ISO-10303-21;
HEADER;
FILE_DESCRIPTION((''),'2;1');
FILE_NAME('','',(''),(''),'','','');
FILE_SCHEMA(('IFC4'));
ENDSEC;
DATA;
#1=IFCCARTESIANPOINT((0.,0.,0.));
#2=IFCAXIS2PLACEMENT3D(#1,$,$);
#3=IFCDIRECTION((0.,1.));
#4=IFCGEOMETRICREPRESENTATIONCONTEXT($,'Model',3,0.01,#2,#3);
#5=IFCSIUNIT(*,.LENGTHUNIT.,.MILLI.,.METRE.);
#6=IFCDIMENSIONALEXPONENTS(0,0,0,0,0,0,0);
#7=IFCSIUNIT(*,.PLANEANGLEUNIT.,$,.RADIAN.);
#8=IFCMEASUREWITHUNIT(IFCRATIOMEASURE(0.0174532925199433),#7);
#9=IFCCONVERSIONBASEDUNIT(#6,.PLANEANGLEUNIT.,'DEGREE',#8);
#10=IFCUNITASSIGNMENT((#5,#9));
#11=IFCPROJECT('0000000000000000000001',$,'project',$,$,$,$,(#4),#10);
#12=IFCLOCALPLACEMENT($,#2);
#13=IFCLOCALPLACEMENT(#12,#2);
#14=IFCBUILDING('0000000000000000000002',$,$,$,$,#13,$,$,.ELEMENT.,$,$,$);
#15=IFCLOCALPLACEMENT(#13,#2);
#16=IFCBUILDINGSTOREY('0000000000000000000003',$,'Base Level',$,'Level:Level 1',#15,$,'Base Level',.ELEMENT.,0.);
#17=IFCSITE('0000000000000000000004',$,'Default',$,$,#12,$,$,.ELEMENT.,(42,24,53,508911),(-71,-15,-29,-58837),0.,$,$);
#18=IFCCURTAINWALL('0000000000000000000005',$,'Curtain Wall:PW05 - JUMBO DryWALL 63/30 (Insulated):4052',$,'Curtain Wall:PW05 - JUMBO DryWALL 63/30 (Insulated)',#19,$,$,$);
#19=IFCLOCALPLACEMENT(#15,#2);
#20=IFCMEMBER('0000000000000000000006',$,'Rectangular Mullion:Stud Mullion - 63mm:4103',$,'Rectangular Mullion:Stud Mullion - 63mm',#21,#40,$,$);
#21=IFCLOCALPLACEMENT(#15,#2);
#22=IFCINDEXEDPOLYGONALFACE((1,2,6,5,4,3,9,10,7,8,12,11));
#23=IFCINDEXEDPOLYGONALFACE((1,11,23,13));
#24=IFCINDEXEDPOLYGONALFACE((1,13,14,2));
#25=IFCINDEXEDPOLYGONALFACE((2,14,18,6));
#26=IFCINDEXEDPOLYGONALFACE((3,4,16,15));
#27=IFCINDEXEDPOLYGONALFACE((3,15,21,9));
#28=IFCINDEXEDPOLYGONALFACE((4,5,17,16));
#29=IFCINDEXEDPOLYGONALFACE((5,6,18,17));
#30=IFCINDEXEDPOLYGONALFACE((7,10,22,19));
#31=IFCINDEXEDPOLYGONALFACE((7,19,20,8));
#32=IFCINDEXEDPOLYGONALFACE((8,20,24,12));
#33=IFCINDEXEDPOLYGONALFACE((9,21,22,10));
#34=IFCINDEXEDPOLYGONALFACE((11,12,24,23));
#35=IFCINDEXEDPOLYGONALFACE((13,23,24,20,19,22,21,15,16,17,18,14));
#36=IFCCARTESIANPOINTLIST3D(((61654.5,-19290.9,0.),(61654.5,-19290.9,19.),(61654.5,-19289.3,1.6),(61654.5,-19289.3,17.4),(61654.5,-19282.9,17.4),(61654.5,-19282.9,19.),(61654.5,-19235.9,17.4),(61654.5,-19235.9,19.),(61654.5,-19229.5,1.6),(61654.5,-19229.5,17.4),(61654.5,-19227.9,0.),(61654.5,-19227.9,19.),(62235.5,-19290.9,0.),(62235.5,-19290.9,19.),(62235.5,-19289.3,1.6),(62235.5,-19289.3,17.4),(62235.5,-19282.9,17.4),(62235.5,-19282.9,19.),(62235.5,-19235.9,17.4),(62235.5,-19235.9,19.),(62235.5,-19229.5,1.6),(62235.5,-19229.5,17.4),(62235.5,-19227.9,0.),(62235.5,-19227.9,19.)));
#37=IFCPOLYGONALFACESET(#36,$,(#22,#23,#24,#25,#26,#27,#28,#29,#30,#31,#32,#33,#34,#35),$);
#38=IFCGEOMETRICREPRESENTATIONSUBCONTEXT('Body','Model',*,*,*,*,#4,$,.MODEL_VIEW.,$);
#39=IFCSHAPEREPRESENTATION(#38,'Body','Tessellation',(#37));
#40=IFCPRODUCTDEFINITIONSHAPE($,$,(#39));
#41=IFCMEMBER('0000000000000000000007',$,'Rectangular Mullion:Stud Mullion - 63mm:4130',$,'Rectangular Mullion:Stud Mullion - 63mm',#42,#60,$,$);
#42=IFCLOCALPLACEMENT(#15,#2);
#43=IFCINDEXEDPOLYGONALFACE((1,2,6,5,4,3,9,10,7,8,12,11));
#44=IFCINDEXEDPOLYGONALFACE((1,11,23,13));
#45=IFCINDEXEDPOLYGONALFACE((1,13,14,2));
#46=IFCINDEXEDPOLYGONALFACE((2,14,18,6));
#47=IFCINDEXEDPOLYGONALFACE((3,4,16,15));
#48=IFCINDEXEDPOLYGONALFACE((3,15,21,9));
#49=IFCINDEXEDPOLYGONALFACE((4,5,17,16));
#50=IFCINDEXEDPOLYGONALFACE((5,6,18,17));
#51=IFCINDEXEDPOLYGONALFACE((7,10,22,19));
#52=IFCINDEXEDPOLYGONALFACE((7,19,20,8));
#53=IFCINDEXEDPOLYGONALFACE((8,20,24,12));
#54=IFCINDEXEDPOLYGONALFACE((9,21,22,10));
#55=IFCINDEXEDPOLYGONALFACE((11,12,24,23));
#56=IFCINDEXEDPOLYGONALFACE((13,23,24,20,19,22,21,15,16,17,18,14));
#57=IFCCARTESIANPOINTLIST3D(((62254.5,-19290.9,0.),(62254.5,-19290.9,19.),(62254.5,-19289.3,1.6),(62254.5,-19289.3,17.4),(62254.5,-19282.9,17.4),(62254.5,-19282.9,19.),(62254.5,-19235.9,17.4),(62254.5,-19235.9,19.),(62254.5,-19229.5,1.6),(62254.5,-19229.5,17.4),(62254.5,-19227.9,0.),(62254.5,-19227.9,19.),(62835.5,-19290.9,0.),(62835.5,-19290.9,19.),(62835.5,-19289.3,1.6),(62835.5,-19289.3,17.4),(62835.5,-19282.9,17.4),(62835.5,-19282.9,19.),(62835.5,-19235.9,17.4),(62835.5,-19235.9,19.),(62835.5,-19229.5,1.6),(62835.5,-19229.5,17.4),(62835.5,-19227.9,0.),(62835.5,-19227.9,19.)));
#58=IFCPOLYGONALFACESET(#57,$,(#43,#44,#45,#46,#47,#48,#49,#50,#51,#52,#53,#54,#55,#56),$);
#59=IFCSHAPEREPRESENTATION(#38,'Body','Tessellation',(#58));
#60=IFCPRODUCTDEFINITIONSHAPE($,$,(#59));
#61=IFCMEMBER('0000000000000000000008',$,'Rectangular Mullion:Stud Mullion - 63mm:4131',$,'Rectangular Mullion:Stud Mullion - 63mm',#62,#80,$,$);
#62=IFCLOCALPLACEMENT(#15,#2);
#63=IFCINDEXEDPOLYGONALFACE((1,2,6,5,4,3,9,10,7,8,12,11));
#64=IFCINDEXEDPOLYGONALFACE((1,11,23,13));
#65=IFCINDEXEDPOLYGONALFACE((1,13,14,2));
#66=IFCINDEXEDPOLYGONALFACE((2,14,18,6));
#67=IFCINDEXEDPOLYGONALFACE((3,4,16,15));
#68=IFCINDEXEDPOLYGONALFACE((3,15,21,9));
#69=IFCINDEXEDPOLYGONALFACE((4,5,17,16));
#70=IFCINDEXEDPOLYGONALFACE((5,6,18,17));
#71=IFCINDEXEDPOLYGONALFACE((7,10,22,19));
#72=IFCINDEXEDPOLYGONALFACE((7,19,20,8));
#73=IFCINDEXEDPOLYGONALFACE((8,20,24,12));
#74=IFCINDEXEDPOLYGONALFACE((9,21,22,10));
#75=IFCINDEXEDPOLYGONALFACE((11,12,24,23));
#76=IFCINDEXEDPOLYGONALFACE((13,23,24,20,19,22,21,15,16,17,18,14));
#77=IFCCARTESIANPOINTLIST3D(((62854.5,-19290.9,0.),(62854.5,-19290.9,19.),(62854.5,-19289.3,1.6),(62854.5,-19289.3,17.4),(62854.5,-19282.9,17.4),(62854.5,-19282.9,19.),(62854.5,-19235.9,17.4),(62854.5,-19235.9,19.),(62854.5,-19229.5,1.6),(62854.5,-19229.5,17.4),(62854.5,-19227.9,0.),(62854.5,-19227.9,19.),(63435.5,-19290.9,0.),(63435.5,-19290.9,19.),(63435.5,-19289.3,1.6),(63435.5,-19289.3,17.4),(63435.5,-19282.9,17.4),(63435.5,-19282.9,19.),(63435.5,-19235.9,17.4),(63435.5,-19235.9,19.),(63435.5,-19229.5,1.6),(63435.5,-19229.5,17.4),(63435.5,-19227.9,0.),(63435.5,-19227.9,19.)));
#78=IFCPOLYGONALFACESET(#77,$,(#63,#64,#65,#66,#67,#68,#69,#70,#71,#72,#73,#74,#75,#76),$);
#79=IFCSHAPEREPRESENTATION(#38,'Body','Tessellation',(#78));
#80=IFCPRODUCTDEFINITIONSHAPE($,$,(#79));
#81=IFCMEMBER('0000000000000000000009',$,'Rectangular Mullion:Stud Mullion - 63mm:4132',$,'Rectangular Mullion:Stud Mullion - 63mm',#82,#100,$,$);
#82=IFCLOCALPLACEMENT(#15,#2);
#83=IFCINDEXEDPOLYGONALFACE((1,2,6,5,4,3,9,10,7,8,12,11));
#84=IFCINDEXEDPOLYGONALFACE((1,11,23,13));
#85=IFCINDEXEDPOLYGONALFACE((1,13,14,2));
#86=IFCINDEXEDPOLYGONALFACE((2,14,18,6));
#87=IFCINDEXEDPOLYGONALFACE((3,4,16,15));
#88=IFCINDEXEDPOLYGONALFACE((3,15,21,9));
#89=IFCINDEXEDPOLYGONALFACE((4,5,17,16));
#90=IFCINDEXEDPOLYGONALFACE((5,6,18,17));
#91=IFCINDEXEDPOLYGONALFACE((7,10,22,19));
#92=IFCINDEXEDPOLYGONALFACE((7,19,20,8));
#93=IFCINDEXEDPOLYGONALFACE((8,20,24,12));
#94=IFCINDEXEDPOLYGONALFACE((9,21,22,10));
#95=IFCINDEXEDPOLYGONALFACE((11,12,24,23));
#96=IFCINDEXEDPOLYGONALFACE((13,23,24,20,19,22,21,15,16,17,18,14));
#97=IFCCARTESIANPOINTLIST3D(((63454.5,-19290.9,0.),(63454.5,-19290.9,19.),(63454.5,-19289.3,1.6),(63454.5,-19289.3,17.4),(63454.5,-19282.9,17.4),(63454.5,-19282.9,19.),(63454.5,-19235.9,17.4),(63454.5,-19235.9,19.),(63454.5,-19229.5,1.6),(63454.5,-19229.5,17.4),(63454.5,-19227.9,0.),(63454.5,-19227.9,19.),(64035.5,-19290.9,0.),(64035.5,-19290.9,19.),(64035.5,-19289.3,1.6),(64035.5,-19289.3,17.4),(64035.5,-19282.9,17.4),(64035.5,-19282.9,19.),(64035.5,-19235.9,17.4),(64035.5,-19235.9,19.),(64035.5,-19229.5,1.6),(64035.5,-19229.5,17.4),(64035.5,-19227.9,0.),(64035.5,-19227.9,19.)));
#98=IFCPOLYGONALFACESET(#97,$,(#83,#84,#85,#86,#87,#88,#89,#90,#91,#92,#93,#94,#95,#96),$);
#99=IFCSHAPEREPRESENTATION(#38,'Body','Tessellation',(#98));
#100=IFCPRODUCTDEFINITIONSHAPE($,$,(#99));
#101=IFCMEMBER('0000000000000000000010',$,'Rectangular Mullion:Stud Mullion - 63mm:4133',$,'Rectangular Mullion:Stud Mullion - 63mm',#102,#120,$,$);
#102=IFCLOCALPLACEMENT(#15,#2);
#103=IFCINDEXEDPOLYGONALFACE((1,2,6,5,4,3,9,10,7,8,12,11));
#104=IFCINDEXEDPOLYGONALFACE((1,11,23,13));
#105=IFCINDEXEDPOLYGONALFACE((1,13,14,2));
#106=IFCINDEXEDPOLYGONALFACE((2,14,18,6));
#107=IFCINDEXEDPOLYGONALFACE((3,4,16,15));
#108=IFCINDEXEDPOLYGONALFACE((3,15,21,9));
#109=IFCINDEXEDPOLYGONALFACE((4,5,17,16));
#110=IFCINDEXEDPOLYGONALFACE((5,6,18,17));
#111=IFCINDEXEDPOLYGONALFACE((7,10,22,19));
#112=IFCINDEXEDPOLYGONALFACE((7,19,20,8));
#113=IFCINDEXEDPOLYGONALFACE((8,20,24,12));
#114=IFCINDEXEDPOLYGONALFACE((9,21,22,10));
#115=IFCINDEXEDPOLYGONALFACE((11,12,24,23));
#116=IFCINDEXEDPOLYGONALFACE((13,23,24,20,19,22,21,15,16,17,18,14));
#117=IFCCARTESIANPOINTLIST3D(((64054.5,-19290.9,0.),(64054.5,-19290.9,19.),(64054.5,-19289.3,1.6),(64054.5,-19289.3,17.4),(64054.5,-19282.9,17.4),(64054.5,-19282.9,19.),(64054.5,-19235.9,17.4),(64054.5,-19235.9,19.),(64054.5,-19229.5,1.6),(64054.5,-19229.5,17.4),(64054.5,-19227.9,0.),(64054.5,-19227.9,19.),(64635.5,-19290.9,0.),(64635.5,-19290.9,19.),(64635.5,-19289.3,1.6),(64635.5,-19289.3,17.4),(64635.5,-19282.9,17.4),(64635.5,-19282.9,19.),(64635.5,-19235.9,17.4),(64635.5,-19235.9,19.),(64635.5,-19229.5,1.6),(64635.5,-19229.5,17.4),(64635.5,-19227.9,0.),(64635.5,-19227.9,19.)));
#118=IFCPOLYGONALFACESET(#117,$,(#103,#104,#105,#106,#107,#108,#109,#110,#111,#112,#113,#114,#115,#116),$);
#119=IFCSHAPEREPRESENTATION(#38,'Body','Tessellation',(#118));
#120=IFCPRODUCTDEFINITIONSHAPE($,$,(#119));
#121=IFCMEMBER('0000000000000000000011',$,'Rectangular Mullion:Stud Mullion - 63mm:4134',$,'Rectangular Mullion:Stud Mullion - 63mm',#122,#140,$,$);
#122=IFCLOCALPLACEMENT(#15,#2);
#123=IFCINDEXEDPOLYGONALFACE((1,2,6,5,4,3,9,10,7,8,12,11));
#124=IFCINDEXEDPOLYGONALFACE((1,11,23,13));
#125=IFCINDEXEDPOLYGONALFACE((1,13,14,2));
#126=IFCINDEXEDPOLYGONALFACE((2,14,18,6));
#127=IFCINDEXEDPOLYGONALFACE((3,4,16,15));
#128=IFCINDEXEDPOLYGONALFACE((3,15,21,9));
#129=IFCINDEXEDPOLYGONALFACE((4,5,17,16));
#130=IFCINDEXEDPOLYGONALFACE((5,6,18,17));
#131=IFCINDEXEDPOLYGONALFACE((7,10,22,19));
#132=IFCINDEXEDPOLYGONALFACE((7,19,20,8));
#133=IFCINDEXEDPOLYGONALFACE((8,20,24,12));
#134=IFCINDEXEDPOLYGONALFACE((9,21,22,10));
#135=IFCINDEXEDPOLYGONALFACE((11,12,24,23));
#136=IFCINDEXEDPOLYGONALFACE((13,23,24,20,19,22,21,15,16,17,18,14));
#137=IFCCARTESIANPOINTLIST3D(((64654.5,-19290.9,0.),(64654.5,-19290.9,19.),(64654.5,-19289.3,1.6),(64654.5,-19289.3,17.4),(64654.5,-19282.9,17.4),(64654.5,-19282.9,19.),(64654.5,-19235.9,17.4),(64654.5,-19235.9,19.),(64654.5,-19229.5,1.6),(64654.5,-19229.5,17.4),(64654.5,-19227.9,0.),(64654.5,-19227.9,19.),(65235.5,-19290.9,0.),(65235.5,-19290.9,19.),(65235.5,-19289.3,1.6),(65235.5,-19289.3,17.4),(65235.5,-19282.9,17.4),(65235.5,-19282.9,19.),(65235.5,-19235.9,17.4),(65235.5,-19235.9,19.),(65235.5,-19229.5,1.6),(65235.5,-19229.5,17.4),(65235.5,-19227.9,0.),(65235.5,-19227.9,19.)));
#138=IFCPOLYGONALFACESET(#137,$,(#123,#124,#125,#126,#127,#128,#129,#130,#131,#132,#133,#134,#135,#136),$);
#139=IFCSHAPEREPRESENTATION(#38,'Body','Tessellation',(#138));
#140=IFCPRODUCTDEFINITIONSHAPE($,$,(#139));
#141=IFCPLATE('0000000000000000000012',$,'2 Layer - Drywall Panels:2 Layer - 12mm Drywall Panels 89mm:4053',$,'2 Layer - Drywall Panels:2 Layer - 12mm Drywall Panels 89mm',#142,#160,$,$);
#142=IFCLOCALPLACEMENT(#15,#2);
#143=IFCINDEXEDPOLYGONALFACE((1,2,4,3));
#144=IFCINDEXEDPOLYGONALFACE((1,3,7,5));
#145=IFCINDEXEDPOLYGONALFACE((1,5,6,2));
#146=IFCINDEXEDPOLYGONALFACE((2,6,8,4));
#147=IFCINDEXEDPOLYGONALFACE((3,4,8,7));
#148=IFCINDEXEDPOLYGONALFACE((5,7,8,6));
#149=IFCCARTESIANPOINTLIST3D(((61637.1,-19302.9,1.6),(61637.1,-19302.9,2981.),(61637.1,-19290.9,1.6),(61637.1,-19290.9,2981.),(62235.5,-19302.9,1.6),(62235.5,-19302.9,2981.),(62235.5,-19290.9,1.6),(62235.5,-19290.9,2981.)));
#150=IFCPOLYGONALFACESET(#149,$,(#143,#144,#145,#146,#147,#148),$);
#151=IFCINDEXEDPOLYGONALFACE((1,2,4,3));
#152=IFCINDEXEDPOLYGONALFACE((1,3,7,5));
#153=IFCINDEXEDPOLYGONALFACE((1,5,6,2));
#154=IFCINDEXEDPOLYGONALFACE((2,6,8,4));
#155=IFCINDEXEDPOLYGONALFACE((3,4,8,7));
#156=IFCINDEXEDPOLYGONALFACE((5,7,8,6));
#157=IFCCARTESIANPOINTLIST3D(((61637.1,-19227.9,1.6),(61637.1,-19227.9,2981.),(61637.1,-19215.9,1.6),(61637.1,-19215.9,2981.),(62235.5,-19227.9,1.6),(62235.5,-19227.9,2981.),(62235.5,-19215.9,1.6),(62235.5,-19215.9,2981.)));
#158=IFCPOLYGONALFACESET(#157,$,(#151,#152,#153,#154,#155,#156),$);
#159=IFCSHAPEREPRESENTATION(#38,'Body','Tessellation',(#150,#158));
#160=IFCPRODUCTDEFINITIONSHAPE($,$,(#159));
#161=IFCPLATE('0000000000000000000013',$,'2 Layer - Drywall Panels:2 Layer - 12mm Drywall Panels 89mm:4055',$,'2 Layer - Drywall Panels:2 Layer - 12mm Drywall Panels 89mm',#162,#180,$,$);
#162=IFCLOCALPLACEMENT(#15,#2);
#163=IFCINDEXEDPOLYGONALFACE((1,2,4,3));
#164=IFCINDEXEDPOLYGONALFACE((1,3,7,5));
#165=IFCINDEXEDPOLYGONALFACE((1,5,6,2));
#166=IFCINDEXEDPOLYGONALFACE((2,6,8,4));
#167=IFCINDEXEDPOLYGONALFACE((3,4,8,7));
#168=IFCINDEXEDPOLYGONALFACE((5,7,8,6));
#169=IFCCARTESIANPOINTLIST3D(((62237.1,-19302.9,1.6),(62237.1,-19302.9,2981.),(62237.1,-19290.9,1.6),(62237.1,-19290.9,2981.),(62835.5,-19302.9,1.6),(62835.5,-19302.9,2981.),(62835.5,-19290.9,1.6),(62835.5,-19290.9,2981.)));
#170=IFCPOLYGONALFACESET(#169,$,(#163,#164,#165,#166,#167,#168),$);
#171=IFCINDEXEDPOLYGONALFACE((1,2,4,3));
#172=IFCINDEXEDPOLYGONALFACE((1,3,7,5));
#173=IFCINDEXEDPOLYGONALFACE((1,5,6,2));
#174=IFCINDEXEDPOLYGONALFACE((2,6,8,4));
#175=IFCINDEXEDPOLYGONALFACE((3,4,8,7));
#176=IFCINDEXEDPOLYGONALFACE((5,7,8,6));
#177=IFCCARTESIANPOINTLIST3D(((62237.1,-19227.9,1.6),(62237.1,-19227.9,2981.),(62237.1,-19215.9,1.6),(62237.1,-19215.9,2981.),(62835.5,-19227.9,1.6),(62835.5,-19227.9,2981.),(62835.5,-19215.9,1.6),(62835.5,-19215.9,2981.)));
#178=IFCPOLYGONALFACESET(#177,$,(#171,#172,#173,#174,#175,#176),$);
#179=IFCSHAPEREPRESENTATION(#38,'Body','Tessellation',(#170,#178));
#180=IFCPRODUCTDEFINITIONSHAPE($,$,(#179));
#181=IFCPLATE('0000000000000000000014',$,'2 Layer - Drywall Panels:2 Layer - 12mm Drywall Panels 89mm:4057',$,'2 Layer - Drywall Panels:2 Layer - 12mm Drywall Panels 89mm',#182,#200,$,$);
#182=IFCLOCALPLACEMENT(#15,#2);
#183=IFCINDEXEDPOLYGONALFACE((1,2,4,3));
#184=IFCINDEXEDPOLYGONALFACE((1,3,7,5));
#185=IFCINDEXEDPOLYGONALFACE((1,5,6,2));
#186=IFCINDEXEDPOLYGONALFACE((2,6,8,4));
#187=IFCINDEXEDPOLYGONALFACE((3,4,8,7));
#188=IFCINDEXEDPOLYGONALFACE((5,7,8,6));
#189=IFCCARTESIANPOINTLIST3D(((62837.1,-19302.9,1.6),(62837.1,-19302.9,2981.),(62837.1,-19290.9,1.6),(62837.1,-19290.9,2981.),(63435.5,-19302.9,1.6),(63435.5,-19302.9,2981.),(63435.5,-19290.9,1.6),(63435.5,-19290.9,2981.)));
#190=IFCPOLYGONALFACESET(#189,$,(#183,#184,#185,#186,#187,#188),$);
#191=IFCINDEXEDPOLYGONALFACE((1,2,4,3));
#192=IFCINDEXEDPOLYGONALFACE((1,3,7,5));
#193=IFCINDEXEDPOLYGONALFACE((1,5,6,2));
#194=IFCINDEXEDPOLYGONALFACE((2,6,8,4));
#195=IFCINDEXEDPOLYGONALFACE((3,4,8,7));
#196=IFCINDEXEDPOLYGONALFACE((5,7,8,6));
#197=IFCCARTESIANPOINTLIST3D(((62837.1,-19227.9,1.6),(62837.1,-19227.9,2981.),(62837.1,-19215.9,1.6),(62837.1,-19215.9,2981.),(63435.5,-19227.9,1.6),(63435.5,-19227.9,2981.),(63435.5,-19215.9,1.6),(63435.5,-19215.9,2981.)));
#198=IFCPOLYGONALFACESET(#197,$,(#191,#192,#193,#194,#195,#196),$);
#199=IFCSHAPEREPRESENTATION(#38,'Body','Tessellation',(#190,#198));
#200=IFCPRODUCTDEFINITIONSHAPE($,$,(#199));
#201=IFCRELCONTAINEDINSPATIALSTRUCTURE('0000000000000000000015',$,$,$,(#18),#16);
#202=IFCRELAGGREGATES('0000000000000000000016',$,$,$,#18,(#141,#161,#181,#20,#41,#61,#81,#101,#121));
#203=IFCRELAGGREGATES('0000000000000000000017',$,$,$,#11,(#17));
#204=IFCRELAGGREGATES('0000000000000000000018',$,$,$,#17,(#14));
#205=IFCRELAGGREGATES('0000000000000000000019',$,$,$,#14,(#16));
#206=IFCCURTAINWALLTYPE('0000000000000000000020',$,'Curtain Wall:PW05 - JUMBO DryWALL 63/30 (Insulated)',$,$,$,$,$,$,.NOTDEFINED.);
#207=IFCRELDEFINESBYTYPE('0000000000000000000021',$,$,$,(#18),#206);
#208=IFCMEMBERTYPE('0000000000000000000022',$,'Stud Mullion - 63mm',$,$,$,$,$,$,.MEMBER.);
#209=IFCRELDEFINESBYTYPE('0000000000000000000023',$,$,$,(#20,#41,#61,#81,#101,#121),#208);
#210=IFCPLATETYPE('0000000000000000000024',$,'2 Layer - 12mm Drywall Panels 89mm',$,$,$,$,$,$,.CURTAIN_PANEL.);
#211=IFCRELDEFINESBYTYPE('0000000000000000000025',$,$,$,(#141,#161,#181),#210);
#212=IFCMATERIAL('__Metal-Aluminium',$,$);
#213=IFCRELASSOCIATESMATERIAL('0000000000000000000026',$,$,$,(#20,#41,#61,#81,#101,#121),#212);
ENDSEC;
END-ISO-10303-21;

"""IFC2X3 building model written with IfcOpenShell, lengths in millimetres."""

from ifc_helpers import new_model, entity, si_unit, converted_unit, direction, frame, frame_2d, origin, place, context, subcontext, project, spatial, polyline, rectangle, outline, extrude, source, transform, mapped, material, type_object, type_shapes, element, aggregate, save


model = new_model("IFC2X3")

# Units and contexts
model_context = context("Model", 3, precision=0.01, world=origin(), true_north=direction((0.0, 1.0)))
body_context = subcontext(model_context, "Body", "Model", "MODEL_VIEW")
ifc_project = project(units=[si_unit("LENGTHUNIT", "METRE", prefix="MILLI"), converted_unit("PLANEANGLEUNIT", "DEGREE", entity("IfcRatioMeasure", 0.0174532925199433), si_unit("PLANEANGLEUNIT", "RADIAN"), dimensions=[0, 0, 0, 0, 0, 0, 0])], contexts=[model_context])

# Site, building, storey
site_placement = place(None, origin())
site = spatial("IfcSite", under=ifc_project, at=site_placement, Name="Default", CompositionType="ELEMENT", RefLatitude=(42, 24, 53, 508911), RefLongitude=(-71, -15, -29, -58837), RefElevation=0.0)
building_placement = place(site_placement, origin())
building = spatial("IfcBuilding", under=site, at=building_placement, CompositionType="ELEMENT")
storey_placement = place(building_placement, origin())
storey = spatial("IfcBuildingStorey", under=building, at=storey_placement, Name="Base Level", ObjectType="Level:Level 1", LongName="Base Level", CompositionType="ELEMENT", Elevation=0.0)

# Curtain wall, members, plates
curtain_wall_type = type_object("IfcCurtainWallType", Name="Curtain Wall:PW05 - JUMBO DryWALL 63/30 (Insulated)", PredefinedType="NOTDEFINED")
curtain_wall_placement = place(building_placement, origin())
curtain_wall = element("IfcCurtainWall", 1, at=curtain_wall_placement, inside=storey, type_object=curtain_wall_type, Name="Curtain Wall:PW05 - JUMBO DryWALL 63/30 (Insulated):4052", ObjectType="Curtain Wall:PW05 - JUMBO DryWALL 63/30 (Insulated)")
ifc_material_1 = material(Name="__Metal-Aluminium")
member_type_1 = type_object("IfcMemberType", Name="Stud Mullion - 63mm", PredefinedType="MEMBER")
shared_shape_1 = source(origin(), body_context, "Body", "SweptSolid", [
    extrude(outline(polyline([(23.5, -6.6), (31.5, -6.6), (31.5, 12.4), (-31.5, 12.4), (-31.5, -6.6), (-23.5, -6.6), (-23.5, -5.0), (-29.9, -5.0), (-29.9, 10.8), (29.9, 10.8), (29.9, -5.0), (23.5, -5.0), (23.5, -6.6)])), frame((-12.4, 0.0, -581.0), z_axis=(0.0, 0.0, 1.0), x_axis=(0.0, -1.0, 0.0)), (0.0, 0.0, 1.0), 581.0),
])
type_shapes(member_type_1, [shared_shape_1])
member_1_placement = place(building_placement, frame((61654.5, -19259.4, 0.0), z_axis=(-1.0, 0.0, 0.0), x_axis=(0.0, 0.0, -1.0)))
member_1 = element("IfcMember", 2, at=member_1_placement, type_object=member_type_1, material=ifc_material_1, Name="Rectangular Mullion:Stud Mullion - 63mm:4103", ObjectType="Rectangular Mullion:Stud Mullion - 63mm", context=body_context, shape_type="MappedRepresentation", body=[
    mapped(shared_shape_1, transform((0.0, 0.0, 0.0), scale=1.0)),
])
member_2_placement = place(building_placement, frame((62254.5, -19259.4, 0.0), z_axis=(-1.0, 0.0, 0.0), x_axis=(0.0, 0.0, -1.0)))
member_2 = element("IfcMember", 3, at=member_2_placement, type_object=member_type_1, material=ifc_material_1, Name="Rectangular Mullion:Stud Mullion - 63mm:4130", ObjectType="Rectangular Mullion:Stud Mullion - 63mm", context=body_context, shape_type="MappedRepresentation", body=[
    mapped(shared_shape_1, transform((0.0, 0.0, 0.0), scale=1.0)),
])
member_3_placement = place(building_placement, frame((62854.5, -19259.4, 0.0), z_axis=(-1.0, 0.0, 0.0), x_axis=(0.0, 0.0, -1.0)))
member_3 = element("IfcMember", 4, at=member_3_placement, type_object=member_type_1, material=ifc_material_1, Name="Rectangular Mullion:Stud Mullion - 63mm:4131", ObjectType="Rectangular Mullion:Stud Mullion - 63mm", context=body_context, shape_type="MappedRepresentation", body=[
    mapped(shared_shape_1, transform((0.0, 0.0, 0.0), scale=1.0)),
])
member_4_placement = place(building_placement, frame((63454.5, -19259.4, 0.0), z_axis=(-1.0, 0.0, 0.0), x_axis=(0.0, 0.0, -1.0)))
member_4 = element("IfcMember", 5, at=member_4_placement, type_object=member_type_1, material=ifc_material_1, Name="Rectangular Mullion:Stud Mullion - 63mm:4132", ObjectType="Rectangular Mullion:Stud Mullion - 63mm", context=body_context, shape_type="MappedRepresentation", body=[
    mapped(shared_shape_1, transform((0.0, 0.0, 0.0), scale=1.0)),
])
member_5_placement = place(building_placement, frame((64054.5, -19259.4, 0.0), z_axis=(-1.0, 0.0, 0.0), x_axis=(0.0, 0.0, -1.0)))
member_5 = element("IfcMember", 6, at=member_5_placement, type_object=member_type_1, material=ifc_material_1, Name="Rectangular Mullion:Stud Mullion - 63mm:4133", ObjectType="Rectangular Mullion:Stud Mullion - 63mm", context=body_context, shape_type="MappedRepresentation", body=[
    mapped(shared_shape_1, transform((0.0, 0.0, 0.0), scale=1.0)),
])
member_6_placement = place(building_placement, frame((64654.5, -19259.4, 0.0), z_axis=(-1.0, 0.0, 0.0), x_axis=(0.0, 0.0, -1.0)))
member_6 = element("IfcMember", 7, at=member_6_placement, type_object=member_type_1, material=ifc_material_1, Name="Rectangular Mullion:Stud Mullion - 63mm:4134", ObjectType="Rectangular Mullion:Stud Mullion - 63mm", context=body_context, shape_type="MappedRepresentation", body=[
    mapped(shared_shape_1, transform((0.0, 0.0, 0.0), scale=1.0)),
])
plate_type = type_object("IfcPlateType", Name="2 Layer - 12mm Drywall Panels 89mm", PredefinedType="CURTAIN_PANEL")
shared_shape_2 = source(origin(), body_context, "Body", "SweptSolid", [
    extrude(rectangle(XDim=598.4, YDim=12.0, at=frame_2d((0.0, 0.0), x_axis=(1.0, 0.0))), frame((0.0, -37.5, 0.0), z_axis=(0.0, 0.0, 1.0), x_axis=(-1.0, 0.0, 0.0)), (0.0, 0.0, 1.0), 2979.4),
    extrude(rectangle(XDim=12.0, YDim=598.4, at=frame_2d((0.0, 0.0), x_axis=(1.0, 0.0))), frame((0.0, 37.5, 0.0), z_axis=(0.0, 0.0, 1.0), x_axis=(0.0, 1.0, 0.0)), (0.0, 0.0, 1.0), 2979.4),
])
type_shapes(plate_type, [shared_shape_2])
plate_1_placement = place(curtain_wall_placement, frame((61936.3, -19259.4, 1.6)))
plate_1 = element("IfcPlate", 8, at=plate_1_placement, type_object=plate_type, Name="2 Layer - Drywall Panels:2 Layer - 12mm Drywall Panels 89mm:4053", ObjectType="2 Layer - Drywall Panels:2 Layer - 12mm Drywall Panels 89mm", context=body_context, shape_type="MappedRepresentation", body=[
    mapped(shared_shape_2, transform((0.0, 0.0, 0.0), scale=1.0)),
])
plate_2_placement = place(curtain_wall_placement, frame((62536.3, -19259.4, 1.6)))
plate_2 = element("IfcPlate", 9, at=plate_2_placement, type_object=plate_type, Name="2 Layer - Drywall Panels:2 Layer - 12mm Drywall Panels 89mm:4055", ObjectType="2 Layer - Drywall Panels:2 Layer - 12mm Drywall Panels 89mm", context=body_context, shape_type="MappedRepresentation", body=[
    mapped(shared_shape_2, transform((0.0, 0.0, 0.0), scale=1.0)),
])
plate_3_placement = place(curtain_wall_placement, frame((63136.3, -19259.4, 1.6)))
plate_3 = element("IfcPlate", 10, at=plate_3_placement, type_object=plate_type, Name="2 Layer - Drywall Panels:2 Layer - 12mm Drywall Panels 89mm:4057", ObjectType="2 Layer - Drywall Panels:2 Layer - 12mm Drywall Panels 89mm", context=body_context, shape_type="MappedRepresentation", body=[
    mapped(shared_shape_2, transform((0.0, 0.0, 0.0), scale=1.0)),
])
aggregate(curtain_wall, [plate_1, plate_2, plate_3, member_1, member_2, member_3, member_4, member_5, member_6])

save(model, "model.ifc")
